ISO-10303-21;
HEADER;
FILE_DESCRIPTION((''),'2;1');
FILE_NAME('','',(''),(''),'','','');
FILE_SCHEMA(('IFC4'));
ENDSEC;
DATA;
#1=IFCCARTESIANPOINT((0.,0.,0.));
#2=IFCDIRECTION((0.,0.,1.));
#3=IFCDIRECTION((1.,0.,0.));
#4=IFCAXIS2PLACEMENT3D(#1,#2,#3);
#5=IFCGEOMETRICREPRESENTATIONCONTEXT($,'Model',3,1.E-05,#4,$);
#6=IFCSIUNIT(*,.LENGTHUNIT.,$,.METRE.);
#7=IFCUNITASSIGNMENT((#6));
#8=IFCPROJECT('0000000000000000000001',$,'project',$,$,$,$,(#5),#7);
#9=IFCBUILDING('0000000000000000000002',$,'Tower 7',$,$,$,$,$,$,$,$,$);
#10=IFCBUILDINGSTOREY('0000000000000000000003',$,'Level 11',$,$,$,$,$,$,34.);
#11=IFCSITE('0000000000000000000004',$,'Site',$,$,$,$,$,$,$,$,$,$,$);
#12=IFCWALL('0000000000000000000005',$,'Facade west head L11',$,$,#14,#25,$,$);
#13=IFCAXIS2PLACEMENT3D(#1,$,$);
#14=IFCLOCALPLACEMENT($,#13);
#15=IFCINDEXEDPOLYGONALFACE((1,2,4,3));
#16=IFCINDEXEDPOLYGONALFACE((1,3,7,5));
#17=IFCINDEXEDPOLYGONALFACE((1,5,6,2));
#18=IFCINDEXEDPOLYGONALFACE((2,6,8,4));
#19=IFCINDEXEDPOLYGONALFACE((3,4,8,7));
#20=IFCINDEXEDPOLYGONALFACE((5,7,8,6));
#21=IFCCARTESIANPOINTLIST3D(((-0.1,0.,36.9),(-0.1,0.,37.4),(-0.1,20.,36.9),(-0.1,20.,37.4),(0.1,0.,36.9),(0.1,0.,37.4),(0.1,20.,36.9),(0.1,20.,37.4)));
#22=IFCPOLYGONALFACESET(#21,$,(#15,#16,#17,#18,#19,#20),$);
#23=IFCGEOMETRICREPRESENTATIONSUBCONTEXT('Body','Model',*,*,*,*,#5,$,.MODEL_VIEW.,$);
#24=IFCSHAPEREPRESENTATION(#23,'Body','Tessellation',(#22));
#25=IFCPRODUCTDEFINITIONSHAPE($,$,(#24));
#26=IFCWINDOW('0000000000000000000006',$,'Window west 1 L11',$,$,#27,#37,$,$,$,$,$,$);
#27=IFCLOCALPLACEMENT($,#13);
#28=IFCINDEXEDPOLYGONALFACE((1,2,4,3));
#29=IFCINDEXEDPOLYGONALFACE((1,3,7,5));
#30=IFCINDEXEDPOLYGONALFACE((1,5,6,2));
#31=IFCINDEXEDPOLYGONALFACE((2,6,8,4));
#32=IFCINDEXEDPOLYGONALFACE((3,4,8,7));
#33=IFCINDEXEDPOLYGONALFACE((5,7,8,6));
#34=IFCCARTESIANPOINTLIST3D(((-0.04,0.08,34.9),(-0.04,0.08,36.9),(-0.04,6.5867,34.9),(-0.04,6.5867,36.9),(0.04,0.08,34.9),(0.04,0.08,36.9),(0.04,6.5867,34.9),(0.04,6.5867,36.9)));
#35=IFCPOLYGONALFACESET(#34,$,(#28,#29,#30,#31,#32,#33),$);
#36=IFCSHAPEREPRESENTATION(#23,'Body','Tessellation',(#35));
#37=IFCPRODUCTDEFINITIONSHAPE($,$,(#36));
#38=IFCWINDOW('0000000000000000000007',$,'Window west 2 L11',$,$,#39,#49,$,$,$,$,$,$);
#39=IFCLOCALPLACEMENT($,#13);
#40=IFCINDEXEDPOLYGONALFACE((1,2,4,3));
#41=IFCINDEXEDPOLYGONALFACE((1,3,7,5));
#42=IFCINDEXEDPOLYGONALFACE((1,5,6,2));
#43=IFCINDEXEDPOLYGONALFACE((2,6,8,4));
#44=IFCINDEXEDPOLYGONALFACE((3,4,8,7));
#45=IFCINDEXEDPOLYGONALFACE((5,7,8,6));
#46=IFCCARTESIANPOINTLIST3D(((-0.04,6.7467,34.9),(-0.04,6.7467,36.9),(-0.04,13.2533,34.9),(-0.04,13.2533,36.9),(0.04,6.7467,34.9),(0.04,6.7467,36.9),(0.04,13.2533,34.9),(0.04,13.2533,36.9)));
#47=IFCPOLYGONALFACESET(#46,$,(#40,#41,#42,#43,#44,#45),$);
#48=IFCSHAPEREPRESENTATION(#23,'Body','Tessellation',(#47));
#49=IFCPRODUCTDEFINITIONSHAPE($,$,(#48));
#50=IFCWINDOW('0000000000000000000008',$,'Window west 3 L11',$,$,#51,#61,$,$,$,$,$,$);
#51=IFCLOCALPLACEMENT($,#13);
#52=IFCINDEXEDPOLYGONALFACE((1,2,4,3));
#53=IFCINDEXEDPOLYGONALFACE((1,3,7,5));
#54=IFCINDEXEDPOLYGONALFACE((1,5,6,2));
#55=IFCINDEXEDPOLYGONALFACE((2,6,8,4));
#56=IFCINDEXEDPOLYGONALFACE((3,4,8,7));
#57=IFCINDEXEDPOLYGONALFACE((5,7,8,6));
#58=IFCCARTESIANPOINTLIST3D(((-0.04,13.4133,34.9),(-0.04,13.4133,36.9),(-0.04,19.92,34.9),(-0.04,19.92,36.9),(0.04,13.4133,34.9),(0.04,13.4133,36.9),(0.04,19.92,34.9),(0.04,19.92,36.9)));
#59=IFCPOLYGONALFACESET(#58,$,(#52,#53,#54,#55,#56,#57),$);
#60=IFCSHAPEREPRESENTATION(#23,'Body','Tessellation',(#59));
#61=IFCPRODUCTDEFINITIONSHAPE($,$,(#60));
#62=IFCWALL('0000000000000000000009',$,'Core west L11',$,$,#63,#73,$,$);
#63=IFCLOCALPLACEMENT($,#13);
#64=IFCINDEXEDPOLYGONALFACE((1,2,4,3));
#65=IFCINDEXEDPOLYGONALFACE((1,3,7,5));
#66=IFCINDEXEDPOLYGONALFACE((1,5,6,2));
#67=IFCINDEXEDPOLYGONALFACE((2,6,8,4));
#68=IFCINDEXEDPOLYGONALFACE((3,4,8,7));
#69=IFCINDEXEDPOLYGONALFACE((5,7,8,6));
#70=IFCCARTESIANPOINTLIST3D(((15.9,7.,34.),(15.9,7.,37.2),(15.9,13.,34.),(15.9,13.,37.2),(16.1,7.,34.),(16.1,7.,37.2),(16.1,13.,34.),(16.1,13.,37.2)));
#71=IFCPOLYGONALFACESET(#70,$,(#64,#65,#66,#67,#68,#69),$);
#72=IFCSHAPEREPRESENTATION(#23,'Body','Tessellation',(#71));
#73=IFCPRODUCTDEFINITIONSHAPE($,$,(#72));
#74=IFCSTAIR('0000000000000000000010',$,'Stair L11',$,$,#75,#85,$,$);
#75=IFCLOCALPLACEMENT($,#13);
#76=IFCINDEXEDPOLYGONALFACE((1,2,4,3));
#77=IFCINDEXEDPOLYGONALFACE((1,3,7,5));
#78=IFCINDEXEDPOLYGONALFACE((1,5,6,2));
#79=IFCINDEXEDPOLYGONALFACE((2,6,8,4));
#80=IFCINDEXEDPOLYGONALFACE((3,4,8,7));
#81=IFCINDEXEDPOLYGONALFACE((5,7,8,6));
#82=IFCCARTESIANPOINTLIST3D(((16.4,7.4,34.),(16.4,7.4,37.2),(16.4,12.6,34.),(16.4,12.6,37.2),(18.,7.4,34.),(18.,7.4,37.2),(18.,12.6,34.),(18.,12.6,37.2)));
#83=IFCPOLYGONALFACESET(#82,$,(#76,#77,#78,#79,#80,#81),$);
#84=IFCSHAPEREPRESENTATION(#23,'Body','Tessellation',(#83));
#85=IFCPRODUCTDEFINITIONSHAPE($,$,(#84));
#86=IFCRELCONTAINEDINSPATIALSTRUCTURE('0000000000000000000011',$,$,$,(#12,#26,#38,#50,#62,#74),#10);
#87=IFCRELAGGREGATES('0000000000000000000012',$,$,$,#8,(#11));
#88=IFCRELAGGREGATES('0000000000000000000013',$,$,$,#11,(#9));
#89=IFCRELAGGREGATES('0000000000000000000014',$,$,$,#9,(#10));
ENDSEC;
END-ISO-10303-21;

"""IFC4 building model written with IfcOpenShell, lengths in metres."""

from ifc_helpers import new_model, si_unit, frame, origin, origin_with_axes, origin_2d, place, context, subcontext, project, spatial, rectangle, extrude, element, save


model = new_model("IFC4")

# Units and contexts
model_context = context("Model", 3, precision=1e-05, world=origin_with_axes())
body_context = subcontext(model_context, "Body", "Model", "MODEL_VIEW")
ifc_project = project(units=[si_unit("LENGTHUNIT", "METRE")], contexts=[model_context])

# Site, building, storey
site = spatial("IfcSite", under=ifc_project, Name="Site")
building = spatial("IfcBuilding", under=site, Name="Tower 7")
storey = spatial("IfcBuildingStorey", under=building, Name="Level 11", Elevation=34.0)

# Wall
wall_1_placement = place(None, frame((0.0, 10.0, 36.9), z_axis=(0.0, 0.0, 1.0), x_axis=(1.0, 0.0, 0.0)))
element("IfcWall", 1, at=wall_1_placement, inside=storey, Name="Facade west head L11", context=body_context, shape_type="SweptSolid", body=[
    extrude(rectangle(XDim=0.2, YDim=20.0, at=origin_2d()), origin(), (0.0, 0.0, 1.0), 0.5),
])

# Windows
for number, where, z_axis, x_axis, name in (
    (2, (0.0, 3.3333, 34.9), (0.0, 0.0, 1.0), (1.0, 0.0, 0.0), "Window west 1 L11"),
    (3, (0.0, 10.0, 34.9), (0.0, 0.0, 1.0), (1.0, 0.0, 0.0), "Window west 2 L11"),
):
    element("IfcWindow", number, at=place(None, frame(where, z_axis=z_axis, x_axis=x_axis)), inside=storey, Name=name, context=body_context, shape_type="SweptSolid", body=[
        extrude(rectangle(XDim=0.08, YDim=6.5067, at=origin_2d()), origin(), (0.0, 0.0, 1.0), 2.0),
    ])
window_1_placement = place(None, frame((0.0, 16.6667, 34.9), z_axis=(0.0, 0.0, 1.0), x_axis=(1.0, 0.0, 0.0)))
element("IfcWindow", 4, at=window_1_placement, inside=storey, Name="Window west 3 L11", context=body_context, shape_type="SweptSolid", body=[
    extrude(rectangle(XDim=0.08, YDim=6.5067, at=origin_2d()), origin(), (0.0, 0.0, 1.0), 2.0),
])

# Wall
wall_2_placement = place(None, frame((16.0, 10.0, 34.0), z_axis=(0.0, 0.0, 1.0), x_axis=(1.0, 0.0, 0.0)))
element("IfcWall", 5, at=wall_2_placement, inside=storey, Name="Core west L11", context=body_context, shape_type="SweptSolid", body=[
    extrude(rectangle(XDim=0.2, YDim=6.0, at=origin_2d()), origin(), (0.0, 0.0, 1.0), 3.2),
])

# Stair
stair_placement = place(None, frame((17.2, 10.0, 34.0), z_axis=(0.0, 0.0, 1.0), x_axis=(1.0, 0.0, 0.0)))
element("IfcStair", 6, at=stair_placement, inside=storey, Name="Stair L11", context=body_context, shape_type="SweptSolid", body=[
    extrude(rectangle(XDim=1.6, YDim=5.2, at=origin_2d()), origin(), (0.0, 0.0, 1.0), 3.2),
])

save(model, "model.ifc")
